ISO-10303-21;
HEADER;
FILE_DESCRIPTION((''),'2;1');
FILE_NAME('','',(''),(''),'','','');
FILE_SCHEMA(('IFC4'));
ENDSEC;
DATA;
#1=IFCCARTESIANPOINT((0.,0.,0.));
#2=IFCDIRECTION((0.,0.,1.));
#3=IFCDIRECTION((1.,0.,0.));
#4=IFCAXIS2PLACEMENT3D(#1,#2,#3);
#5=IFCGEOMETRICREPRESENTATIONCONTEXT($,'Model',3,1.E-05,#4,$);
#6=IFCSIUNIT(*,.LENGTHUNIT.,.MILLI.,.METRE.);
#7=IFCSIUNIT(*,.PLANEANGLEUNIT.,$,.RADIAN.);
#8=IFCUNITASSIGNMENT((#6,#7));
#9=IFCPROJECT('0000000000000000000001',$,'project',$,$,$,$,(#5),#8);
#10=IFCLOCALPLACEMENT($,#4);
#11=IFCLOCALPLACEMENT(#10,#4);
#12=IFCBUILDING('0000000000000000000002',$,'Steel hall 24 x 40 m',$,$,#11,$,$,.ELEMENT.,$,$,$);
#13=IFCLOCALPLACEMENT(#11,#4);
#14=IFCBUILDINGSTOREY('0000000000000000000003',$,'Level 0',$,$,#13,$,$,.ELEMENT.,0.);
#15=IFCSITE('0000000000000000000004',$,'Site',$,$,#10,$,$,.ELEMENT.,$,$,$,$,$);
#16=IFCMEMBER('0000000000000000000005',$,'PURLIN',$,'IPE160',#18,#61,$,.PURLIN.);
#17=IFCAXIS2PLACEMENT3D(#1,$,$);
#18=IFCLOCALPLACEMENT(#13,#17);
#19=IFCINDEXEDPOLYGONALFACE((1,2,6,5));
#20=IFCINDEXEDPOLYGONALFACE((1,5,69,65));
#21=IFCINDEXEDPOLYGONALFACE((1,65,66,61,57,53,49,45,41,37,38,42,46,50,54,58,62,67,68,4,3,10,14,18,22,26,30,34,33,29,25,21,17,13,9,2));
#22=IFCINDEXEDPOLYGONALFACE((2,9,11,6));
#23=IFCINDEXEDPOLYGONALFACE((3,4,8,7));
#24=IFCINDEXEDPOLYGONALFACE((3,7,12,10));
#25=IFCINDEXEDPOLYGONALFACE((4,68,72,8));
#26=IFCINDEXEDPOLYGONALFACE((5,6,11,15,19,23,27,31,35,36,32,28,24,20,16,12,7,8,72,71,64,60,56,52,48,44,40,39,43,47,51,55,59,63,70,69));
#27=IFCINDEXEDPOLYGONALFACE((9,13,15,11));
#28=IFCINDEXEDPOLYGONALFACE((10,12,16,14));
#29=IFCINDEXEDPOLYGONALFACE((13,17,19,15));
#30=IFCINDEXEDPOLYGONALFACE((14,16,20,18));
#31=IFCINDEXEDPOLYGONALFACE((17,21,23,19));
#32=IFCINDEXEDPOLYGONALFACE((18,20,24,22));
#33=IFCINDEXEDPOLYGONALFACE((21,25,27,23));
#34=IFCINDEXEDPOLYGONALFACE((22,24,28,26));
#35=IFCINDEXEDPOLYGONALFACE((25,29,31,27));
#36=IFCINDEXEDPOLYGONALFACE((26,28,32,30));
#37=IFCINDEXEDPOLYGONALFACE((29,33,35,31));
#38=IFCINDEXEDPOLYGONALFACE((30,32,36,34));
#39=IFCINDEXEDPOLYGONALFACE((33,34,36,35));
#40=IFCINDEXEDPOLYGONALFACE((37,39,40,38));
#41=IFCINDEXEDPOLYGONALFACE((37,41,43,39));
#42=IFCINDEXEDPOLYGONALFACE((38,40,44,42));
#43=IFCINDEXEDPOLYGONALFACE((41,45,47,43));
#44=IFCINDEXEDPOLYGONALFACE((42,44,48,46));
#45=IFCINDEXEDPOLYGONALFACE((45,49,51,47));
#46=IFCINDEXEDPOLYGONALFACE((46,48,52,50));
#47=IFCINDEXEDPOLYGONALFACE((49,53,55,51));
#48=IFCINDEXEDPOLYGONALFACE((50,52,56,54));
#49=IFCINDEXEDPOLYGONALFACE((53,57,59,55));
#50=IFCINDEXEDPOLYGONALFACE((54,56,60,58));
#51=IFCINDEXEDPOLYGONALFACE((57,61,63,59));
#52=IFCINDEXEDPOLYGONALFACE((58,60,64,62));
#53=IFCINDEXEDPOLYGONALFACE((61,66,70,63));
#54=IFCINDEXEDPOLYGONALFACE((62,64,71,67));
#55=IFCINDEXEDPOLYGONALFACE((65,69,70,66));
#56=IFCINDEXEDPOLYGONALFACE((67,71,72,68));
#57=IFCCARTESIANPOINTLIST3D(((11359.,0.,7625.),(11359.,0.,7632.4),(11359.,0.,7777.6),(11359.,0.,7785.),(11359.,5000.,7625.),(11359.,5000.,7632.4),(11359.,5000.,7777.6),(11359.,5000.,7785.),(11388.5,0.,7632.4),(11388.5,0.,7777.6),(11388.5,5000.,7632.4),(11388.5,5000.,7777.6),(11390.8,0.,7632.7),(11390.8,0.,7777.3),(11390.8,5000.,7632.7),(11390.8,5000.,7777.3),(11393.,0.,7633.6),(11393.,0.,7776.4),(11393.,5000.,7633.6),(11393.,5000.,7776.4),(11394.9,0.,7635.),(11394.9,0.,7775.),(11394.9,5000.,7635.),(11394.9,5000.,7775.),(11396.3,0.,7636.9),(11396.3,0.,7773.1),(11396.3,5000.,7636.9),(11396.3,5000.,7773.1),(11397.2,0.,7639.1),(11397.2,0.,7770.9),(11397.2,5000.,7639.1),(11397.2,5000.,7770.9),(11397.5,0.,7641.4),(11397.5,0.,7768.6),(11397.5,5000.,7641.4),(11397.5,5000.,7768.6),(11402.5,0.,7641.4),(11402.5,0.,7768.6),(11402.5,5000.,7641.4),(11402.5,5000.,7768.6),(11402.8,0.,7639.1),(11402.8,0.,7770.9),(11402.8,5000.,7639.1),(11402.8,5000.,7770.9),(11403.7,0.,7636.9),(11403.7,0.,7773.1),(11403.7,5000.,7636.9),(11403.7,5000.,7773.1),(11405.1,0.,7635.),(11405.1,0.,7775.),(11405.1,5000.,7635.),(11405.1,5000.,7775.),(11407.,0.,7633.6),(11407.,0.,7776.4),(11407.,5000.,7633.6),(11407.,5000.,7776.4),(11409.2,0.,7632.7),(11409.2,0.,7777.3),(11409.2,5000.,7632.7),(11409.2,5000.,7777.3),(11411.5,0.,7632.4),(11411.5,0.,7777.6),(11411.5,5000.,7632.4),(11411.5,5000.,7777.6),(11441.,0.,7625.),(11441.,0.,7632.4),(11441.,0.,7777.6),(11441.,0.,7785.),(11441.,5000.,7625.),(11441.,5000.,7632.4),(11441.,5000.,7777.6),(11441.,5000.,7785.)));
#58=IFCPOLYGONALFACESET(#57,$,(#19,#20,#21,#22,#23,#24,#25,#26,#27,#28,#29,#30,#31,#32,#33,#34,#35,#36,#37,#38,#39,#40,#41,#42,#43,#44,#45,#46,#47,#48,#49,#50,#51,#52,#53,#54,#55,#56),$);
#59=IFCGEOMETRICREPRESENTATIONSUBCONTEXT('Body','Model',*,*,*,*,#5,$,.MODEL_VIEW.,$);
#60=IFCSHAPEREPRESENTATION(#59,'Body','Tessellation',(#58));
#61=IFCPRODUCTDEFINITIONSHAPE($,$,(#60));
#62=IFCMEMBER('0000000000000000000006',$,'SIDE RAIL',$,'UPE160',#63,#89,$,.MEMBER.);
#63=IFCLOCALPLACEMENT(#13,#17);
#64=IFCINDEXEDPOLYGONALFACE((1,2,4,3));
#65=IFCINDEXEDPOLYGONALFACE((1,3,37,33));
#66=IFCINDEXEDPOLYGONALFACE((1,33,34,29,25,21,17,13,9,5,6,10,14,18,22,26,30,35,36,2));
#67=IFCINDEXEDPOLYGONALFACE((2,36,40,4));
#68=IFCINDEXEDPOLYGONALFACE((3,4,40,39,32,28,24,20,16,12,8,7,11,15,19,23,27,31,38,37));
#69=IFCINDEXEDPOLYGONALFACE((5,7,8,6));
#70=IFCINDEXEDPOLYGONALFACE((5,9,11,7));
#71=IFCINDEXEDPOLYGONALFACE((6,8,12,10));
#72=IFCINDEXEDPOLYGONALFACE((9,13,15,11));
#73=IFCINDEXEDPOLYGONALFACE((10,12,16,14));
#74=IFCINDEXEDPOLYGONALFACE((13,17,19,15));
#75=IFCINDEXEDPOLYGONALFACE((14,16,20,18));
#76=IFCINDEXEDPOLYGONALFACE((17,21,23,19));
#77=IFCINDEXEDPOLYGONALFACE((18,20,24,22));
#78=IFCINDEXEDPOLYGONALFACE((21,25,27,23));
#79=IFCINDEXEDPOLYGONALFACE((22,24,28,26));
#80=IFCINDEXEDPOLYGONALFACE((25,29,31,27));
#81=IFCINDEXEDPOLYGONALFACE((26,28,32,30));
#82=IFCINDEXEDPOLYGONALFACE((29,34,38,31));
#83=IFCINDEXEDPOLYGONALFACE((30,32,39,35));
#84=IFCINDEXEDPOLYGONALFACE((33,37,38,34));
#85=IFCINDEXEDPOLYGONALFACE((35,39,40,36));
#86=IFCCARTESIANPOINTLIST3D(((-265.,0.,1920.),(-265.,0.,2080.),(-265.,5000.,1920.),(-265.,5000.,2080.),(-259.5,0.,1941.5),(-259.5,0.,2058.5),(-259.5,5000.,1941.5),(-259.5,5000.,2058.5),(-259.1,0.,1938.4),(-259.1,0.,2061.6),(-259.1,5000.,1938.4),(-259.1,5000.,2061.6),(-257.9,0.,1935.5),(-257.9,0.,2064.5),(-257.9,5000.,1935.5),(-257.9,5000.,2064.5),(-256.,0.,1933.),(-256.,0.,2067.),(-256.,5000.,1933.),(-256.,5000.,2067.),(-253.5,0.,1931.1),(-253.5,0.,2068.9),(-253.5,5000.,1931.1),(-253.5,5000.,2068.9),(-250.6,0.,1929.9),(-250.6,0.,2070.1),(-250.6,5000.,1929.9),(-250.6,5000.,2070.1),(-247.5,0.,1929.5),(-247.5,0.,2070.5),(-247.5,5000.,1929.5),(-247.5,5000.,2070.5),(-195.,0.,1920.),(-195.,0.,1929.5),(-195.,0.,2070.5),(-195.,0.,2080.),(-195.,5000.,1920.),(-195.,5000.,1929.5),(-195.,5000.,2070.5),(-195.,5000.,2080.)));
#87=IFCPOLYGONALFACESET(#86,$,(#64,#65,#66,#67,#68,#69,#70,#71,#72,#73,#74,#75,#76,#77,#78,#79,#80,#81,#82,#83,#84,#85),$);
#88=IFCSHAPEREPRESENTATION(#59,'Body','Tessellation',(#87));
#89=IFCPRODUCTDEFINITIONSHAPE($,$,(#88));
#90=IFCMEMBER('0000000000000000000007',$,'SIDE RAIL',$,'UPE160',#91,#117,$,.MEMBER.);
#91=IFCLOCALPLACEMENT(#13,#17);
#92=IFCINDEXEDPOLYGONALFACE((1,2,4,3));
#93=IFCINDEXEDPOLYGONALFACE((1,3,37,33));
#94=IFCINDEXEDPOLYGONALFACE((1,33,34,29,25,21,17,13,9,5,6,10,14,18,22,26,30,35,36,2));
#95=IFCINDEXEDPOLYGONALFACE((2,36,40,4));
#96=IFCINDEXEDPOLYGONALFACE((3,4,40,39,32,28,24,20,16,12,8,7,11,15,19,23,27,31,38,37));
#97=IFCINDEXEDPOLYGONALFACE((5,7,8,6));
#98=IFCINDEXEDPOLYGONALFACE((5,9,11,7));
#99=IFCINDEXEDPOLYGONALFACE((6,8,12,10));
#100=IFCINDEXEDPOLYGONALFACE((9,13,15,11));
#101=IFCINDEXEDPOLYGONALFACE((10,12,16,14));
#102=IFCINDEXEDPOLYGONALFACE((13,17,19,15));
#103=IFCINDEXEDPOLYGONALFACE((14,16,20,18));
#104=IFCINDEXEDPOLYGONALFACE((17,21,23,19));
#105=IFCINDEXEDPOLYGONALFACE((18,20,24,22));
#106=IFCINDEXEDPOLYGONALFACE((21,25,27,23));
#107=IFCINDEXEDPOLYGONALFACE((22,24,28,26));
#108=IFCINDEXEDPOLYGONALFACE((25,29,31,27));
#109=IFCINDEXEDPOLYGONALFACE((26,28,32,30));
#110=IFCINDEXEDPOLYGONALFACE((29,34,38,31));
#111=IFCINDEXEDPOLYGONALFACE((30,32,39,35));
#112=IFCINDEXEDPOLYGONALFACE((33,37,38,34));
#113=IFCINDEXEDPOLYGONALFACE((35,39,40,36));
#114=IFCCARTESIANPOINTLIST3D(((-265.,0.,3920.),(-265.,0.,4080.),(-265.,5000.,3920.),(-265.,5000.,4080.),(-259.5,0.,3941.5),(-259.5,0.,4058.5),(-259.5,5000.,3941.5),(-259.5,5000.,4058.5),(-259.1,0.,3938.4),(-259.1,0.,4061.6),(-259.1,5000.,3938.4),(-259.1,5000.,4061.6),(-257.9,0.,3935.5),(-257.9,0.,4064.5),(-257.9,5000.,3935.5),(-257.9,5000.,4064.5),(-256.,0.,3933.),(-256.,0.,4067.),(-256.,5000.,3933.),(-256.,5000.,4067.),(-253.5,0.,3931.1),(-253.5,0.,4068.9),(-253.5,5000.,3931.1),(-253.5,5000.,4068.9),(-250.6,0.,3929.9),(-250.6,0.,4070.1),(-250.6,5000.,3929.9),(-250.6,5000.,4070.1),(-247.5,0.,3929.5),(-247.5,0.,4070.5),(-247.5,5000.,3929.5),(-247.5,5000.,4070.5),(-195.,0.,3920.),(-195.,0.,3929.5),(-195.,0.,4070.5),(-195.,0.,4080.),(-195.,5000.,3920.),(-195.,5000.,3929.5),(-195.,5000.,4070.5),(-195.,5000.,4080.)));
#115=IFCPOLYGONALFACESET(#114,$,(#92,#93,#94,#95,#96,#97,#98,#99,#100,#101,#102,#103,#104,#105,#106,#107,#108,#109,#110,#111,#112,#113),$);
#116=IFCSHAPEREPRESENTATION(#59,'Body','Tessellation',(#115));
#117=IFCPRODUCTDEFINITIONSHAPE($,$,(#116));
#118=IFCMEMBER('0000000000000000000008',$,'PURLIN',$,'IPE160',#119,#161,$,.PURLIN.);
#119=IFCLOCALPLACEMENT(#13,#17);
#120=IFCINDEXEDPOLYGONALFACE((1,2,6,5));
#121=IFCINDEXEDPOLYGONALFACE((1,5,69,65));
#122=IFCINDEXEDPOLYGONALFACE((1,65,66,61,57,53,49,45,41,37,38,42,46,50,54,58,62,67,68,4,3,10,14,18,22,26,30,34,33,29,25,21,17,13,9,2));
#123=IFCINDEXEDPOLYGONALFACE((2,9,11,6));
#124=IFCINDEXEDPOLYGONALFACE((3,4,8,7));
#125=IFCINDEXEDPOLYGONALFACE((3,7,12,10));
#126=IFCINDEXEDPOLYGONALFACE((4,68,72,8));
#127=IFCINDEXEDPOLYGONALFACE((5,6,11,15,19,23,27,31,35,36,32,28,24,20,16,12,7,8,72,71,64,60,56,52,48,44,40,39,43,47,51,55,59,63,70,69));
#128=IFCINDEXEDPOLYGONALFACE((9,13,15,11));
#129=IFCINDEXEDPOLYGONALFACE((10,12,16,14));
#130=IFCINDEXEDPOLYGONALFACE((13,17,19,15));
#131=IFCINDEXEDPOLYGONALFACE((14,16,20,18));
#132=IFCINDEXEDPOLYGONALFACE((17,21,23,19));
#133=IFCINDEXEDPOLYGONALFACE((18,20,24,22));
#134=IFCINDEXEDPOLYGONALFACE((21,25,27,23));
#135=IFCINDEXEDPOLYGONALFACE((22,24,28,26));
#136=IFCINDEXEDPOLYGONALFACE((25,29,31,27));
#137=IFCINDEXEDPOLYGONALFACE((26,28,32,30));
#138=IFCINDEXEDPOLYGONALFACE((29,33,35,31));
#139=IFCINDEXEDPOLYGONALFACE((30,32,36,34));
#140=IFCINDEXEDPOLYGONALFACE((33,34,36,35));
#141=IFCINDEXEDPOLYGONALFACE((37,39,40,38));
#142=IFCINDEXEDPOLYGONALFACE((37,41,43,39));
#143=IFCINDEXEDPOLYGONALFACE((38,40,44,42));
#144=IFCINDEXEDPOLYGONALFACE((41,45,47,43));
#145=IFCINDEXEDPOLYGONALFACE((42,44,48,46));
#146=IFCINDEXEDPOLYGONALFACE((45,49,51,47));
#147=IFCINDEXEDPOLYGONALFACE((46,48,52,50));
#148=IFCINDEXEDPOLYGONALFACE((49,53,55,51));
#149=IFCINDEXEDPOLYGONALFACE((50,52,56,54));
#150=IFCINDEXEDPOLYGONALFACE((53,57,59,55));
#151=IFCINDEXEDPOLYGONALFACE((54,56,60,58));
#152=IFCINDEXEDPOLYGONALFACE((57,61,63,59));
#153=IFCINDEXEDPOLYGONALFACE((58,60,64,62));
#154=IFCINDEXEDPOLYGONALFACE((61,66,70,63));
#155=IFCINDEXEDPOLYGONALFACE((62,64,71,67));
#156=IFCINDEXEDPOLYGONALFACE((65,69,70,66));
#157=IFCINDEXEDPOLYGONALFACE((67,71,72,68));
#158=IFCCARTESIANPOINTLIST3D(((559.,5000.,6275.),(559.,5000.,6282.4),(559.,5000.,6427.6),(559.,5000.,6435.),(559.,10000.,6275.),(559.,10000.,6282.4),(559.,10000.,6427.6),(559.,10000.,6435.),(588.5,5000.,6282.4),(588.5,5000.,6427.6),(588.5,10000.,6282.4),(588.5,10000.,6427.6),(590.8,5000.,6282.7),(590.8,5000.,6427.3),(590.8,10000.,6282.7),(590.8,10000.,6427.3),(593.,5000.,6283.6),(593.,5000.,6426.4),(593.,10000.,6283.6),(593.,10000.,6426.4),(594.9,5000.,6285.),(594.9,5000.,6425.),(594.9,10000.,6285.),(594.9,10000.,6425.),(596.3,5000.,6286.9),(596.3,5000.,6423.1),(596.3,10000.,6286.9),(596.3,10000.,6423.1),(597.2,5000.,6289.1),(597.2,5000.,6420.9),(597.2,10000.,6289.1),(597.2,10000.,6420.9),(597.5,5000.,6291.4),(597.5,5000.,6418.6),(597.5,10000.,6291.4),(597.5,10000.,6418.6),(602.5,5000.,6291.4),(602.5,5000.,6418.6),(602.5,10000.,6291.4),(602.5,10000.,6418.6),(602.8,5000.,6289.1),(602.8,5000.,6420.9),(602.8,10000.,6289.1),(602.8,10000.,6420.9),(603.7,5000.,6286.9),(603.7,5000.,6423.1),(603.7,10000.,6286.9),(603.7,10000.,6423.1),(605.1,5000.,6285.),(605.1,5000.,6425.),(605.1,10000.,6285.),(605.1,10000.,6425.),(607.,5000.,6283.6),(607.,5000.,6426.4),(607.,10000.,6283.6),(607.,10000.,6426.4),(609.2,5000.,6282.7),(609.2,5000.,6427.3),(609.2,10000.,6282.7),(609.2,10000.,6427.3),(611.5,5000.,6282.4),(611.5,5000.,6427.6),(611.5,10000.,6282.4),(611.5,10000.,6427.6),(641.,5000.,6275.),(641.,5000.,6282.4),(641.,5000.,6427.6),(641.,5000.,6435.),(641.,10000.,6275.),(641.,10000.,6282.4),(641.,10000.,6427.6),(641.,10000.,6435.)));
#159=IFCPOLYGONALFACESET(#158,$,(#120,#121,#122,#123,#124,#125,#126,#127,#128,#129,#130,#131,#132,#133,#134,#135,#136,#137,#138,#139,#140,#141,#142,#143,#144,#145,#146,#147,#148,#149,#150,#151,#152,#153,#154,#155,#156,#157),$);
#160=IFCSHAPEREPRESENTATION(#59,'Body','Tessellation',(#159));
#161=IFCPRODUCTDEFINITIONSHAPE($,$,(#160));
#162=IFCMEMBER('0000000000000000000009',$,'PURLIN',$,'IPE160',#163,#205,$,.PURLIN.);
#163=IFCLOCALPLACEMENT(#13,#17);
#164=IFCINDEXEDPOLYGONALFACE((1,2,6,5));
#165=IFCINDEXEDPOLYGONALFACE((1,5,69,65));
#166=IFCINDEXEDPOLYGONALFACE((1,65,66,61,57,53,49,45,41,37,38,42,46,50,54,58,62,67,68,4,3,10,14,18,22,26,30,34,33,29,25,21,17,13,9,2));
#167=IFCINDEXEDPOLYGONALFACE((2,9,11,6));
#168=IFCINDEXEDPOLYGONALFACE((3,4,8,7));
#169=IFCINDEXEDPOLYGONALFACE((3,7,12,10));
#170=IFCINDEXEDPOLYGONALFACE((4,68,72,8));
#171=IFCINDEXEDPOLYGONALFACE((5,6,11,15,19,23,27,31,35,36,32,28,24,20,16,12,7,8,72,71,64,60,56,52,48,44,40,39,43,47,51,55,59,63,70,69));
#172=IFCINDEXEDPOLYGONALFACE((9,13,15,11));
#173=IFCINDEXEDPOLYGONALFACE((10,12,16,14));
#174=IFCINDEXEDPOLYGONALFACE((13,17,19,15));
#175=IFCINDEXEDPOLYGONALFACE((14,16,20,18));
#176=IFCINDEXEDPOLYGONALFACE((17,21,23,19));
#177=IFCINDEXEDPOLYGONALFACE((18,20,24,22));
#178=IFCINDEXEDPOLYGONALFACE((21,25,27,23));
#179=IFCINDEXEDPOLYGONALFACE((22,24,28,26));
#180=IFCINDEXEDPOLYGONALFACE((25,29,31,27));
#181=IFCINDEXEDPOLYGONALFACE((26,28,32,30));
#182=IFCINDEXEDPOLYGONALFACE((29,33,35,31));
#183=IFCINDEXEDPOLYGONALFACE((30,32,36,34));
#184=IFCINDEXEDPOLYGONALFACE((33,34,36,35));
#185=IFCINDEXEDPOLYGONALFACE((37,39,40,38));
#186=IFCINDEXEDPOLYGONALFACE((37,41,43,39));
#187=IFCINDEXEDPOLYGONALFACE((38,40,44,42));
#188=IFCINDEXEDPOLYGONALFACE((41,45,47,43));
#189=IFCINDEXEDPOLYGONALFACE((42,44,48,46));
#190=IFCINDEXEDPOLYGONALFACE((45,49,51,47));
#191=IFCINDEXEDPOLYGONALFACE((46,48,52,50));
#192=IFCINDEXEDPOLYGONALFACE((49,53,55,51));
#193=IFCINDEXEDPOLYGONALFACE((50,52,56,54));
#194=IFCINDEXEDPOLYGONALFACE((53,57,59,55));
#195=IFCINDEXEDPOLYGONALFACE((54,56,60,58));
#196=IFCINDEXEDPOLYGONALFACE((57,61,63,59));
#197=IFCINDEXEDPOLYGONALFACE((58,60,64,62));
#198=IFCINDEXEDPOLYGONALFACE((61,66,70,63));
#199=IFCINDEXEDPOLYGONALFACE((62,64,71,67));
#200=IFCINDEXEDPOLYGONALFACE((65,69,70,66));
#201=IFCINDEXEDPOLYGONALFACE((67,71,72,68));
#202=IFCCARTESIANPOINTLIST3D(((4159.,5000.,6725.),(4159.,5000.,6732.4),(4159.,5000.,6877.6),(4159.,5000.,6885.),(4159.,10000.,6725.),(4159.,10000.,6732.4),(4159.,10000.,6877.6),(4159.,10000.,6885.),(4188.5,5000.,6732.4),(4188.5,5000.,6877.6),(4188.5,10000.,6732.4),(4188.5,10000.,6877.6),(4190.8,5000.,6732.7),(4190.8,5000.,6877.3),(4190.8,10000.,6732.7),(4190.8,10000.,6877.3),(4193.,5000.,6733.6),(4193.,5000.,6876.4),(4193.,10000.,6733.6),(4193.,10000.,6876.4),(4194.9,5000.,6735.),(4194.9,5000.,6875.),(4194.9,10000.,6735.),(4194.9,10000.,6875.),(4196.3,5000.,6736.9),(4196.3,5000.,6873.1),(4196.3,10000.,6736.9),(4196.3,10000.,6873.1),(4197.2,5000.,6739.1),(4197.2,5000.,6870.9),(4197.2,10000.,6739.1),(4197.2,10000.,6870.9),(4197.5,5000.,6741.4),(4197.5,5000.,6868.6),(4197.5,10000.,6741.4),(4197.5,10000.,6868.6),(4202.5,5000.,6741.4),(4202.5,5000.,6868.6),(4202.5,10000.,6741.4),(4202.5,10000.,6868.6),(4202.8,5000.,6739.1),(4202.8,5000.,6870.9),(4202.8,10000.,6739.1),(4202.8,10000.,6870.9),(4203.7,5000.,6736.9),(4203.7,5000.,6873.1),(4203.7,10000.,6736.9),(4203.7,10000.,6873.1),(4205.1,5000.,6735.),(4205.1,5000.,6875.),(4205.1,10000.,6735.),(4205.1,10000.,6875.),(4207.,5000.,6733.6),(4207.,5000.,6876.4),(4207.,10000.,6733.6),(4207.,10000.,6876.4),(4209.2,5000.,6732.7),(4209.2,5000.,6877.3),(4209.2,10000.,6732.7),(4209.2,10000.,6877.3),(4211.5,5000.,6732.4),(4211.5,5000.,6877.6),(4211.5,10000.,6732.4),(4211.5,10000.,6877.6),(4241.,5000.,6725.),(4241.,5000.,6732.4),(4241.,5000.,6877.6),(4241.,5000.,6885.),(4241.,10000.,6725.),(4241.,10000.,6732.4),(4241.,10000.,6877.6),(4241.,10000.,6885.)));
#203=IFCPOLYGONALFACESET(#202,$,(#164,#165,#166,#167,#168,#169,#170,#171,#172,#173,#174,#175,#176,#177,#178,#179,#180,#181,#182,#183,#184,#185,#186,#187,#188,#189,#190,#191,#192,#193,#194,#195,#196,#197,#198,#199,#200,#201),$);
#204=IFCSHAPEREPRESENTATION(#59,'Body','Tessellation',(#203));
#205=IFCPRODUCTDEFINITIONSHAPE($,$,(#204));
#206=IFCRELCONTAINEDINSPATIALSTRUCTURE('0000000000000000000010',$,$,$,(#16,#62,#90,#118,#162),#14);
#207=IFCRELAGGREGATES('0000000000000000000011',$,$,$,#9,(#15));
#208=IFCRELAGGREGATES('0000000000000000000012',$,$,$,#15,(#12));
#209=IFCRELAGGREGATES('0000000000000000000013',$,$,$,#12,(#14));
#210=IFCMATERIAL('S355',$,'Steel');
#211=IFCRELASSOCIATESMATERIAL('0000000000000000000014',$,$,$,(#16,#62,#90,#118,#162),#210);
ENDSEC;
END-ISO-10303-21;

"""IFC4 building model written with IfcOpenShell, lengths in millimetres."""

from ifc_helpers import new_model, si_unit, frame, origin_with_axes, place, context, subcontext, project, spatial, i_section, u_section, extrude, material, element, save


model = new_model("IFC4")

# Units and contexts
model_context = context("Model", 3, precision=1e-05, world=origin_with_axes())
body_context = subcontext(model_context, "Body", "Model", "MODEL_VIEW")
ifc_project = project(units=[si_unit("LENGTHUNIT", "METRE", prefix="MILLI"), si_unit("PLANEANGLEUNIT", "RADIAN")], contexts=[model_context])

# Site, building, storey
site_placement = place(None, origin_with_axes())
site = spatial("IfcSite", under=ifc_project, at=site_placement, Name="Site", CompositionType="ELEMENT")
building_placement = place(site_placement, origin_with_axes())
building = spatial("IfcBuilding", under=site, at=building_placement, Name="Steel hall 24 x 40 m", CompositionType="ELEMENT")
storey_placement = place(building_placement, origin_with_axes())
storey = spatial("IfcBuildingStorey", under=building, at=storey_placement, Name="Level 0", CompositionType="ELEMENT", Elevation=0.0)

# Shared definitions
ifc_material = material(Name="S355", Category="Steel")

# Members
for number, where, z_axis, x_axis, name in (
    (1, (11400.0, 0.0, 7705.0), (0.0, 1.0, 0.0), (1.0, 0.0, 0.0), "PURLIN"),
):
    element("IfcMember", number, at=place(storey_placement, frame(where, z_axis=z_axis, x_axis=x_axis)), inside=storey, material=ifc_material, Name=name, ObjectType="IPE160", PredefinedType="PURLIN", context=body_context, shape_type="SweptSolid", body=[
        extrude(i_section(OverallWidth=82.0, OverallDepth=160.0, WebThickness=5.0, FlangeThickness=7.4, FilletRadius=9.0), origin_with_axes(), (0.0, 0.0, 1.0), 5000.0),
    ])
for number, where, z_axis, x_axis, name in (
    (2, (-230.0, 0.0, 2000.0), (0.0, 1.0, 0.0), (1.0, 0.0, 0.0), "SIDE RAIL"),
    (3, (-230.0, 0.0, 4000.0), (0.0, 1.0, 0.0), (1.0, 0.0, 0.0), "SIDE RAIL"),
):
    element("IfcMember", number, at=place(storey_placement, frame(where, z_axis=z_axis, x_axis=x_axis)), inside=storey, material=ifc_material, Name=name, ObjectType="UPE160", PredefinedType="MEMBER", context=body_context, shape_type="SweptSolid", body=[
        extrude(u_section(Depth=160.0, FlangeWidth=70.0, WebThickness=5.5, FlangeThickness=9.5, FilletRadius=12.0), origin_with_axes(), (0.0, 0.0, 1.0), 5000.0),
    ])
for number, where, z_axis, x_axis, name in (
    (4, (600.0, 5000.0, 6355.0), (0.0, 1.0, 0.0), (1.0, 0.0, 0.0), "PURLIN"),
    (5, (4200.0, 5000.0, 6805.0), (0.0, 1.0, 0.0), (1.0, 0.0, 0.0), "PURLIN"),
):
    element("IfcMember", number, at=place(storey_placement, frame(where, z_axis=z_axis, x_axis=x_axis)), inside=storey, material=ifc_material, Name=name, ObjectType="IPE160", PredefinedType="PURLIN", context=body_context, shape_type="SweptSolid", body=[
        extrude(i_section(OverallWidth=82.0, OverallDepth=160.0, WebThickness=5.0, FlangeThickness=7.4, FilletRadius=9.0), origin_with_axes(), (0.0, 0.0, 1.0), 5000.0),
    ])

save(model, "model.ifc")
